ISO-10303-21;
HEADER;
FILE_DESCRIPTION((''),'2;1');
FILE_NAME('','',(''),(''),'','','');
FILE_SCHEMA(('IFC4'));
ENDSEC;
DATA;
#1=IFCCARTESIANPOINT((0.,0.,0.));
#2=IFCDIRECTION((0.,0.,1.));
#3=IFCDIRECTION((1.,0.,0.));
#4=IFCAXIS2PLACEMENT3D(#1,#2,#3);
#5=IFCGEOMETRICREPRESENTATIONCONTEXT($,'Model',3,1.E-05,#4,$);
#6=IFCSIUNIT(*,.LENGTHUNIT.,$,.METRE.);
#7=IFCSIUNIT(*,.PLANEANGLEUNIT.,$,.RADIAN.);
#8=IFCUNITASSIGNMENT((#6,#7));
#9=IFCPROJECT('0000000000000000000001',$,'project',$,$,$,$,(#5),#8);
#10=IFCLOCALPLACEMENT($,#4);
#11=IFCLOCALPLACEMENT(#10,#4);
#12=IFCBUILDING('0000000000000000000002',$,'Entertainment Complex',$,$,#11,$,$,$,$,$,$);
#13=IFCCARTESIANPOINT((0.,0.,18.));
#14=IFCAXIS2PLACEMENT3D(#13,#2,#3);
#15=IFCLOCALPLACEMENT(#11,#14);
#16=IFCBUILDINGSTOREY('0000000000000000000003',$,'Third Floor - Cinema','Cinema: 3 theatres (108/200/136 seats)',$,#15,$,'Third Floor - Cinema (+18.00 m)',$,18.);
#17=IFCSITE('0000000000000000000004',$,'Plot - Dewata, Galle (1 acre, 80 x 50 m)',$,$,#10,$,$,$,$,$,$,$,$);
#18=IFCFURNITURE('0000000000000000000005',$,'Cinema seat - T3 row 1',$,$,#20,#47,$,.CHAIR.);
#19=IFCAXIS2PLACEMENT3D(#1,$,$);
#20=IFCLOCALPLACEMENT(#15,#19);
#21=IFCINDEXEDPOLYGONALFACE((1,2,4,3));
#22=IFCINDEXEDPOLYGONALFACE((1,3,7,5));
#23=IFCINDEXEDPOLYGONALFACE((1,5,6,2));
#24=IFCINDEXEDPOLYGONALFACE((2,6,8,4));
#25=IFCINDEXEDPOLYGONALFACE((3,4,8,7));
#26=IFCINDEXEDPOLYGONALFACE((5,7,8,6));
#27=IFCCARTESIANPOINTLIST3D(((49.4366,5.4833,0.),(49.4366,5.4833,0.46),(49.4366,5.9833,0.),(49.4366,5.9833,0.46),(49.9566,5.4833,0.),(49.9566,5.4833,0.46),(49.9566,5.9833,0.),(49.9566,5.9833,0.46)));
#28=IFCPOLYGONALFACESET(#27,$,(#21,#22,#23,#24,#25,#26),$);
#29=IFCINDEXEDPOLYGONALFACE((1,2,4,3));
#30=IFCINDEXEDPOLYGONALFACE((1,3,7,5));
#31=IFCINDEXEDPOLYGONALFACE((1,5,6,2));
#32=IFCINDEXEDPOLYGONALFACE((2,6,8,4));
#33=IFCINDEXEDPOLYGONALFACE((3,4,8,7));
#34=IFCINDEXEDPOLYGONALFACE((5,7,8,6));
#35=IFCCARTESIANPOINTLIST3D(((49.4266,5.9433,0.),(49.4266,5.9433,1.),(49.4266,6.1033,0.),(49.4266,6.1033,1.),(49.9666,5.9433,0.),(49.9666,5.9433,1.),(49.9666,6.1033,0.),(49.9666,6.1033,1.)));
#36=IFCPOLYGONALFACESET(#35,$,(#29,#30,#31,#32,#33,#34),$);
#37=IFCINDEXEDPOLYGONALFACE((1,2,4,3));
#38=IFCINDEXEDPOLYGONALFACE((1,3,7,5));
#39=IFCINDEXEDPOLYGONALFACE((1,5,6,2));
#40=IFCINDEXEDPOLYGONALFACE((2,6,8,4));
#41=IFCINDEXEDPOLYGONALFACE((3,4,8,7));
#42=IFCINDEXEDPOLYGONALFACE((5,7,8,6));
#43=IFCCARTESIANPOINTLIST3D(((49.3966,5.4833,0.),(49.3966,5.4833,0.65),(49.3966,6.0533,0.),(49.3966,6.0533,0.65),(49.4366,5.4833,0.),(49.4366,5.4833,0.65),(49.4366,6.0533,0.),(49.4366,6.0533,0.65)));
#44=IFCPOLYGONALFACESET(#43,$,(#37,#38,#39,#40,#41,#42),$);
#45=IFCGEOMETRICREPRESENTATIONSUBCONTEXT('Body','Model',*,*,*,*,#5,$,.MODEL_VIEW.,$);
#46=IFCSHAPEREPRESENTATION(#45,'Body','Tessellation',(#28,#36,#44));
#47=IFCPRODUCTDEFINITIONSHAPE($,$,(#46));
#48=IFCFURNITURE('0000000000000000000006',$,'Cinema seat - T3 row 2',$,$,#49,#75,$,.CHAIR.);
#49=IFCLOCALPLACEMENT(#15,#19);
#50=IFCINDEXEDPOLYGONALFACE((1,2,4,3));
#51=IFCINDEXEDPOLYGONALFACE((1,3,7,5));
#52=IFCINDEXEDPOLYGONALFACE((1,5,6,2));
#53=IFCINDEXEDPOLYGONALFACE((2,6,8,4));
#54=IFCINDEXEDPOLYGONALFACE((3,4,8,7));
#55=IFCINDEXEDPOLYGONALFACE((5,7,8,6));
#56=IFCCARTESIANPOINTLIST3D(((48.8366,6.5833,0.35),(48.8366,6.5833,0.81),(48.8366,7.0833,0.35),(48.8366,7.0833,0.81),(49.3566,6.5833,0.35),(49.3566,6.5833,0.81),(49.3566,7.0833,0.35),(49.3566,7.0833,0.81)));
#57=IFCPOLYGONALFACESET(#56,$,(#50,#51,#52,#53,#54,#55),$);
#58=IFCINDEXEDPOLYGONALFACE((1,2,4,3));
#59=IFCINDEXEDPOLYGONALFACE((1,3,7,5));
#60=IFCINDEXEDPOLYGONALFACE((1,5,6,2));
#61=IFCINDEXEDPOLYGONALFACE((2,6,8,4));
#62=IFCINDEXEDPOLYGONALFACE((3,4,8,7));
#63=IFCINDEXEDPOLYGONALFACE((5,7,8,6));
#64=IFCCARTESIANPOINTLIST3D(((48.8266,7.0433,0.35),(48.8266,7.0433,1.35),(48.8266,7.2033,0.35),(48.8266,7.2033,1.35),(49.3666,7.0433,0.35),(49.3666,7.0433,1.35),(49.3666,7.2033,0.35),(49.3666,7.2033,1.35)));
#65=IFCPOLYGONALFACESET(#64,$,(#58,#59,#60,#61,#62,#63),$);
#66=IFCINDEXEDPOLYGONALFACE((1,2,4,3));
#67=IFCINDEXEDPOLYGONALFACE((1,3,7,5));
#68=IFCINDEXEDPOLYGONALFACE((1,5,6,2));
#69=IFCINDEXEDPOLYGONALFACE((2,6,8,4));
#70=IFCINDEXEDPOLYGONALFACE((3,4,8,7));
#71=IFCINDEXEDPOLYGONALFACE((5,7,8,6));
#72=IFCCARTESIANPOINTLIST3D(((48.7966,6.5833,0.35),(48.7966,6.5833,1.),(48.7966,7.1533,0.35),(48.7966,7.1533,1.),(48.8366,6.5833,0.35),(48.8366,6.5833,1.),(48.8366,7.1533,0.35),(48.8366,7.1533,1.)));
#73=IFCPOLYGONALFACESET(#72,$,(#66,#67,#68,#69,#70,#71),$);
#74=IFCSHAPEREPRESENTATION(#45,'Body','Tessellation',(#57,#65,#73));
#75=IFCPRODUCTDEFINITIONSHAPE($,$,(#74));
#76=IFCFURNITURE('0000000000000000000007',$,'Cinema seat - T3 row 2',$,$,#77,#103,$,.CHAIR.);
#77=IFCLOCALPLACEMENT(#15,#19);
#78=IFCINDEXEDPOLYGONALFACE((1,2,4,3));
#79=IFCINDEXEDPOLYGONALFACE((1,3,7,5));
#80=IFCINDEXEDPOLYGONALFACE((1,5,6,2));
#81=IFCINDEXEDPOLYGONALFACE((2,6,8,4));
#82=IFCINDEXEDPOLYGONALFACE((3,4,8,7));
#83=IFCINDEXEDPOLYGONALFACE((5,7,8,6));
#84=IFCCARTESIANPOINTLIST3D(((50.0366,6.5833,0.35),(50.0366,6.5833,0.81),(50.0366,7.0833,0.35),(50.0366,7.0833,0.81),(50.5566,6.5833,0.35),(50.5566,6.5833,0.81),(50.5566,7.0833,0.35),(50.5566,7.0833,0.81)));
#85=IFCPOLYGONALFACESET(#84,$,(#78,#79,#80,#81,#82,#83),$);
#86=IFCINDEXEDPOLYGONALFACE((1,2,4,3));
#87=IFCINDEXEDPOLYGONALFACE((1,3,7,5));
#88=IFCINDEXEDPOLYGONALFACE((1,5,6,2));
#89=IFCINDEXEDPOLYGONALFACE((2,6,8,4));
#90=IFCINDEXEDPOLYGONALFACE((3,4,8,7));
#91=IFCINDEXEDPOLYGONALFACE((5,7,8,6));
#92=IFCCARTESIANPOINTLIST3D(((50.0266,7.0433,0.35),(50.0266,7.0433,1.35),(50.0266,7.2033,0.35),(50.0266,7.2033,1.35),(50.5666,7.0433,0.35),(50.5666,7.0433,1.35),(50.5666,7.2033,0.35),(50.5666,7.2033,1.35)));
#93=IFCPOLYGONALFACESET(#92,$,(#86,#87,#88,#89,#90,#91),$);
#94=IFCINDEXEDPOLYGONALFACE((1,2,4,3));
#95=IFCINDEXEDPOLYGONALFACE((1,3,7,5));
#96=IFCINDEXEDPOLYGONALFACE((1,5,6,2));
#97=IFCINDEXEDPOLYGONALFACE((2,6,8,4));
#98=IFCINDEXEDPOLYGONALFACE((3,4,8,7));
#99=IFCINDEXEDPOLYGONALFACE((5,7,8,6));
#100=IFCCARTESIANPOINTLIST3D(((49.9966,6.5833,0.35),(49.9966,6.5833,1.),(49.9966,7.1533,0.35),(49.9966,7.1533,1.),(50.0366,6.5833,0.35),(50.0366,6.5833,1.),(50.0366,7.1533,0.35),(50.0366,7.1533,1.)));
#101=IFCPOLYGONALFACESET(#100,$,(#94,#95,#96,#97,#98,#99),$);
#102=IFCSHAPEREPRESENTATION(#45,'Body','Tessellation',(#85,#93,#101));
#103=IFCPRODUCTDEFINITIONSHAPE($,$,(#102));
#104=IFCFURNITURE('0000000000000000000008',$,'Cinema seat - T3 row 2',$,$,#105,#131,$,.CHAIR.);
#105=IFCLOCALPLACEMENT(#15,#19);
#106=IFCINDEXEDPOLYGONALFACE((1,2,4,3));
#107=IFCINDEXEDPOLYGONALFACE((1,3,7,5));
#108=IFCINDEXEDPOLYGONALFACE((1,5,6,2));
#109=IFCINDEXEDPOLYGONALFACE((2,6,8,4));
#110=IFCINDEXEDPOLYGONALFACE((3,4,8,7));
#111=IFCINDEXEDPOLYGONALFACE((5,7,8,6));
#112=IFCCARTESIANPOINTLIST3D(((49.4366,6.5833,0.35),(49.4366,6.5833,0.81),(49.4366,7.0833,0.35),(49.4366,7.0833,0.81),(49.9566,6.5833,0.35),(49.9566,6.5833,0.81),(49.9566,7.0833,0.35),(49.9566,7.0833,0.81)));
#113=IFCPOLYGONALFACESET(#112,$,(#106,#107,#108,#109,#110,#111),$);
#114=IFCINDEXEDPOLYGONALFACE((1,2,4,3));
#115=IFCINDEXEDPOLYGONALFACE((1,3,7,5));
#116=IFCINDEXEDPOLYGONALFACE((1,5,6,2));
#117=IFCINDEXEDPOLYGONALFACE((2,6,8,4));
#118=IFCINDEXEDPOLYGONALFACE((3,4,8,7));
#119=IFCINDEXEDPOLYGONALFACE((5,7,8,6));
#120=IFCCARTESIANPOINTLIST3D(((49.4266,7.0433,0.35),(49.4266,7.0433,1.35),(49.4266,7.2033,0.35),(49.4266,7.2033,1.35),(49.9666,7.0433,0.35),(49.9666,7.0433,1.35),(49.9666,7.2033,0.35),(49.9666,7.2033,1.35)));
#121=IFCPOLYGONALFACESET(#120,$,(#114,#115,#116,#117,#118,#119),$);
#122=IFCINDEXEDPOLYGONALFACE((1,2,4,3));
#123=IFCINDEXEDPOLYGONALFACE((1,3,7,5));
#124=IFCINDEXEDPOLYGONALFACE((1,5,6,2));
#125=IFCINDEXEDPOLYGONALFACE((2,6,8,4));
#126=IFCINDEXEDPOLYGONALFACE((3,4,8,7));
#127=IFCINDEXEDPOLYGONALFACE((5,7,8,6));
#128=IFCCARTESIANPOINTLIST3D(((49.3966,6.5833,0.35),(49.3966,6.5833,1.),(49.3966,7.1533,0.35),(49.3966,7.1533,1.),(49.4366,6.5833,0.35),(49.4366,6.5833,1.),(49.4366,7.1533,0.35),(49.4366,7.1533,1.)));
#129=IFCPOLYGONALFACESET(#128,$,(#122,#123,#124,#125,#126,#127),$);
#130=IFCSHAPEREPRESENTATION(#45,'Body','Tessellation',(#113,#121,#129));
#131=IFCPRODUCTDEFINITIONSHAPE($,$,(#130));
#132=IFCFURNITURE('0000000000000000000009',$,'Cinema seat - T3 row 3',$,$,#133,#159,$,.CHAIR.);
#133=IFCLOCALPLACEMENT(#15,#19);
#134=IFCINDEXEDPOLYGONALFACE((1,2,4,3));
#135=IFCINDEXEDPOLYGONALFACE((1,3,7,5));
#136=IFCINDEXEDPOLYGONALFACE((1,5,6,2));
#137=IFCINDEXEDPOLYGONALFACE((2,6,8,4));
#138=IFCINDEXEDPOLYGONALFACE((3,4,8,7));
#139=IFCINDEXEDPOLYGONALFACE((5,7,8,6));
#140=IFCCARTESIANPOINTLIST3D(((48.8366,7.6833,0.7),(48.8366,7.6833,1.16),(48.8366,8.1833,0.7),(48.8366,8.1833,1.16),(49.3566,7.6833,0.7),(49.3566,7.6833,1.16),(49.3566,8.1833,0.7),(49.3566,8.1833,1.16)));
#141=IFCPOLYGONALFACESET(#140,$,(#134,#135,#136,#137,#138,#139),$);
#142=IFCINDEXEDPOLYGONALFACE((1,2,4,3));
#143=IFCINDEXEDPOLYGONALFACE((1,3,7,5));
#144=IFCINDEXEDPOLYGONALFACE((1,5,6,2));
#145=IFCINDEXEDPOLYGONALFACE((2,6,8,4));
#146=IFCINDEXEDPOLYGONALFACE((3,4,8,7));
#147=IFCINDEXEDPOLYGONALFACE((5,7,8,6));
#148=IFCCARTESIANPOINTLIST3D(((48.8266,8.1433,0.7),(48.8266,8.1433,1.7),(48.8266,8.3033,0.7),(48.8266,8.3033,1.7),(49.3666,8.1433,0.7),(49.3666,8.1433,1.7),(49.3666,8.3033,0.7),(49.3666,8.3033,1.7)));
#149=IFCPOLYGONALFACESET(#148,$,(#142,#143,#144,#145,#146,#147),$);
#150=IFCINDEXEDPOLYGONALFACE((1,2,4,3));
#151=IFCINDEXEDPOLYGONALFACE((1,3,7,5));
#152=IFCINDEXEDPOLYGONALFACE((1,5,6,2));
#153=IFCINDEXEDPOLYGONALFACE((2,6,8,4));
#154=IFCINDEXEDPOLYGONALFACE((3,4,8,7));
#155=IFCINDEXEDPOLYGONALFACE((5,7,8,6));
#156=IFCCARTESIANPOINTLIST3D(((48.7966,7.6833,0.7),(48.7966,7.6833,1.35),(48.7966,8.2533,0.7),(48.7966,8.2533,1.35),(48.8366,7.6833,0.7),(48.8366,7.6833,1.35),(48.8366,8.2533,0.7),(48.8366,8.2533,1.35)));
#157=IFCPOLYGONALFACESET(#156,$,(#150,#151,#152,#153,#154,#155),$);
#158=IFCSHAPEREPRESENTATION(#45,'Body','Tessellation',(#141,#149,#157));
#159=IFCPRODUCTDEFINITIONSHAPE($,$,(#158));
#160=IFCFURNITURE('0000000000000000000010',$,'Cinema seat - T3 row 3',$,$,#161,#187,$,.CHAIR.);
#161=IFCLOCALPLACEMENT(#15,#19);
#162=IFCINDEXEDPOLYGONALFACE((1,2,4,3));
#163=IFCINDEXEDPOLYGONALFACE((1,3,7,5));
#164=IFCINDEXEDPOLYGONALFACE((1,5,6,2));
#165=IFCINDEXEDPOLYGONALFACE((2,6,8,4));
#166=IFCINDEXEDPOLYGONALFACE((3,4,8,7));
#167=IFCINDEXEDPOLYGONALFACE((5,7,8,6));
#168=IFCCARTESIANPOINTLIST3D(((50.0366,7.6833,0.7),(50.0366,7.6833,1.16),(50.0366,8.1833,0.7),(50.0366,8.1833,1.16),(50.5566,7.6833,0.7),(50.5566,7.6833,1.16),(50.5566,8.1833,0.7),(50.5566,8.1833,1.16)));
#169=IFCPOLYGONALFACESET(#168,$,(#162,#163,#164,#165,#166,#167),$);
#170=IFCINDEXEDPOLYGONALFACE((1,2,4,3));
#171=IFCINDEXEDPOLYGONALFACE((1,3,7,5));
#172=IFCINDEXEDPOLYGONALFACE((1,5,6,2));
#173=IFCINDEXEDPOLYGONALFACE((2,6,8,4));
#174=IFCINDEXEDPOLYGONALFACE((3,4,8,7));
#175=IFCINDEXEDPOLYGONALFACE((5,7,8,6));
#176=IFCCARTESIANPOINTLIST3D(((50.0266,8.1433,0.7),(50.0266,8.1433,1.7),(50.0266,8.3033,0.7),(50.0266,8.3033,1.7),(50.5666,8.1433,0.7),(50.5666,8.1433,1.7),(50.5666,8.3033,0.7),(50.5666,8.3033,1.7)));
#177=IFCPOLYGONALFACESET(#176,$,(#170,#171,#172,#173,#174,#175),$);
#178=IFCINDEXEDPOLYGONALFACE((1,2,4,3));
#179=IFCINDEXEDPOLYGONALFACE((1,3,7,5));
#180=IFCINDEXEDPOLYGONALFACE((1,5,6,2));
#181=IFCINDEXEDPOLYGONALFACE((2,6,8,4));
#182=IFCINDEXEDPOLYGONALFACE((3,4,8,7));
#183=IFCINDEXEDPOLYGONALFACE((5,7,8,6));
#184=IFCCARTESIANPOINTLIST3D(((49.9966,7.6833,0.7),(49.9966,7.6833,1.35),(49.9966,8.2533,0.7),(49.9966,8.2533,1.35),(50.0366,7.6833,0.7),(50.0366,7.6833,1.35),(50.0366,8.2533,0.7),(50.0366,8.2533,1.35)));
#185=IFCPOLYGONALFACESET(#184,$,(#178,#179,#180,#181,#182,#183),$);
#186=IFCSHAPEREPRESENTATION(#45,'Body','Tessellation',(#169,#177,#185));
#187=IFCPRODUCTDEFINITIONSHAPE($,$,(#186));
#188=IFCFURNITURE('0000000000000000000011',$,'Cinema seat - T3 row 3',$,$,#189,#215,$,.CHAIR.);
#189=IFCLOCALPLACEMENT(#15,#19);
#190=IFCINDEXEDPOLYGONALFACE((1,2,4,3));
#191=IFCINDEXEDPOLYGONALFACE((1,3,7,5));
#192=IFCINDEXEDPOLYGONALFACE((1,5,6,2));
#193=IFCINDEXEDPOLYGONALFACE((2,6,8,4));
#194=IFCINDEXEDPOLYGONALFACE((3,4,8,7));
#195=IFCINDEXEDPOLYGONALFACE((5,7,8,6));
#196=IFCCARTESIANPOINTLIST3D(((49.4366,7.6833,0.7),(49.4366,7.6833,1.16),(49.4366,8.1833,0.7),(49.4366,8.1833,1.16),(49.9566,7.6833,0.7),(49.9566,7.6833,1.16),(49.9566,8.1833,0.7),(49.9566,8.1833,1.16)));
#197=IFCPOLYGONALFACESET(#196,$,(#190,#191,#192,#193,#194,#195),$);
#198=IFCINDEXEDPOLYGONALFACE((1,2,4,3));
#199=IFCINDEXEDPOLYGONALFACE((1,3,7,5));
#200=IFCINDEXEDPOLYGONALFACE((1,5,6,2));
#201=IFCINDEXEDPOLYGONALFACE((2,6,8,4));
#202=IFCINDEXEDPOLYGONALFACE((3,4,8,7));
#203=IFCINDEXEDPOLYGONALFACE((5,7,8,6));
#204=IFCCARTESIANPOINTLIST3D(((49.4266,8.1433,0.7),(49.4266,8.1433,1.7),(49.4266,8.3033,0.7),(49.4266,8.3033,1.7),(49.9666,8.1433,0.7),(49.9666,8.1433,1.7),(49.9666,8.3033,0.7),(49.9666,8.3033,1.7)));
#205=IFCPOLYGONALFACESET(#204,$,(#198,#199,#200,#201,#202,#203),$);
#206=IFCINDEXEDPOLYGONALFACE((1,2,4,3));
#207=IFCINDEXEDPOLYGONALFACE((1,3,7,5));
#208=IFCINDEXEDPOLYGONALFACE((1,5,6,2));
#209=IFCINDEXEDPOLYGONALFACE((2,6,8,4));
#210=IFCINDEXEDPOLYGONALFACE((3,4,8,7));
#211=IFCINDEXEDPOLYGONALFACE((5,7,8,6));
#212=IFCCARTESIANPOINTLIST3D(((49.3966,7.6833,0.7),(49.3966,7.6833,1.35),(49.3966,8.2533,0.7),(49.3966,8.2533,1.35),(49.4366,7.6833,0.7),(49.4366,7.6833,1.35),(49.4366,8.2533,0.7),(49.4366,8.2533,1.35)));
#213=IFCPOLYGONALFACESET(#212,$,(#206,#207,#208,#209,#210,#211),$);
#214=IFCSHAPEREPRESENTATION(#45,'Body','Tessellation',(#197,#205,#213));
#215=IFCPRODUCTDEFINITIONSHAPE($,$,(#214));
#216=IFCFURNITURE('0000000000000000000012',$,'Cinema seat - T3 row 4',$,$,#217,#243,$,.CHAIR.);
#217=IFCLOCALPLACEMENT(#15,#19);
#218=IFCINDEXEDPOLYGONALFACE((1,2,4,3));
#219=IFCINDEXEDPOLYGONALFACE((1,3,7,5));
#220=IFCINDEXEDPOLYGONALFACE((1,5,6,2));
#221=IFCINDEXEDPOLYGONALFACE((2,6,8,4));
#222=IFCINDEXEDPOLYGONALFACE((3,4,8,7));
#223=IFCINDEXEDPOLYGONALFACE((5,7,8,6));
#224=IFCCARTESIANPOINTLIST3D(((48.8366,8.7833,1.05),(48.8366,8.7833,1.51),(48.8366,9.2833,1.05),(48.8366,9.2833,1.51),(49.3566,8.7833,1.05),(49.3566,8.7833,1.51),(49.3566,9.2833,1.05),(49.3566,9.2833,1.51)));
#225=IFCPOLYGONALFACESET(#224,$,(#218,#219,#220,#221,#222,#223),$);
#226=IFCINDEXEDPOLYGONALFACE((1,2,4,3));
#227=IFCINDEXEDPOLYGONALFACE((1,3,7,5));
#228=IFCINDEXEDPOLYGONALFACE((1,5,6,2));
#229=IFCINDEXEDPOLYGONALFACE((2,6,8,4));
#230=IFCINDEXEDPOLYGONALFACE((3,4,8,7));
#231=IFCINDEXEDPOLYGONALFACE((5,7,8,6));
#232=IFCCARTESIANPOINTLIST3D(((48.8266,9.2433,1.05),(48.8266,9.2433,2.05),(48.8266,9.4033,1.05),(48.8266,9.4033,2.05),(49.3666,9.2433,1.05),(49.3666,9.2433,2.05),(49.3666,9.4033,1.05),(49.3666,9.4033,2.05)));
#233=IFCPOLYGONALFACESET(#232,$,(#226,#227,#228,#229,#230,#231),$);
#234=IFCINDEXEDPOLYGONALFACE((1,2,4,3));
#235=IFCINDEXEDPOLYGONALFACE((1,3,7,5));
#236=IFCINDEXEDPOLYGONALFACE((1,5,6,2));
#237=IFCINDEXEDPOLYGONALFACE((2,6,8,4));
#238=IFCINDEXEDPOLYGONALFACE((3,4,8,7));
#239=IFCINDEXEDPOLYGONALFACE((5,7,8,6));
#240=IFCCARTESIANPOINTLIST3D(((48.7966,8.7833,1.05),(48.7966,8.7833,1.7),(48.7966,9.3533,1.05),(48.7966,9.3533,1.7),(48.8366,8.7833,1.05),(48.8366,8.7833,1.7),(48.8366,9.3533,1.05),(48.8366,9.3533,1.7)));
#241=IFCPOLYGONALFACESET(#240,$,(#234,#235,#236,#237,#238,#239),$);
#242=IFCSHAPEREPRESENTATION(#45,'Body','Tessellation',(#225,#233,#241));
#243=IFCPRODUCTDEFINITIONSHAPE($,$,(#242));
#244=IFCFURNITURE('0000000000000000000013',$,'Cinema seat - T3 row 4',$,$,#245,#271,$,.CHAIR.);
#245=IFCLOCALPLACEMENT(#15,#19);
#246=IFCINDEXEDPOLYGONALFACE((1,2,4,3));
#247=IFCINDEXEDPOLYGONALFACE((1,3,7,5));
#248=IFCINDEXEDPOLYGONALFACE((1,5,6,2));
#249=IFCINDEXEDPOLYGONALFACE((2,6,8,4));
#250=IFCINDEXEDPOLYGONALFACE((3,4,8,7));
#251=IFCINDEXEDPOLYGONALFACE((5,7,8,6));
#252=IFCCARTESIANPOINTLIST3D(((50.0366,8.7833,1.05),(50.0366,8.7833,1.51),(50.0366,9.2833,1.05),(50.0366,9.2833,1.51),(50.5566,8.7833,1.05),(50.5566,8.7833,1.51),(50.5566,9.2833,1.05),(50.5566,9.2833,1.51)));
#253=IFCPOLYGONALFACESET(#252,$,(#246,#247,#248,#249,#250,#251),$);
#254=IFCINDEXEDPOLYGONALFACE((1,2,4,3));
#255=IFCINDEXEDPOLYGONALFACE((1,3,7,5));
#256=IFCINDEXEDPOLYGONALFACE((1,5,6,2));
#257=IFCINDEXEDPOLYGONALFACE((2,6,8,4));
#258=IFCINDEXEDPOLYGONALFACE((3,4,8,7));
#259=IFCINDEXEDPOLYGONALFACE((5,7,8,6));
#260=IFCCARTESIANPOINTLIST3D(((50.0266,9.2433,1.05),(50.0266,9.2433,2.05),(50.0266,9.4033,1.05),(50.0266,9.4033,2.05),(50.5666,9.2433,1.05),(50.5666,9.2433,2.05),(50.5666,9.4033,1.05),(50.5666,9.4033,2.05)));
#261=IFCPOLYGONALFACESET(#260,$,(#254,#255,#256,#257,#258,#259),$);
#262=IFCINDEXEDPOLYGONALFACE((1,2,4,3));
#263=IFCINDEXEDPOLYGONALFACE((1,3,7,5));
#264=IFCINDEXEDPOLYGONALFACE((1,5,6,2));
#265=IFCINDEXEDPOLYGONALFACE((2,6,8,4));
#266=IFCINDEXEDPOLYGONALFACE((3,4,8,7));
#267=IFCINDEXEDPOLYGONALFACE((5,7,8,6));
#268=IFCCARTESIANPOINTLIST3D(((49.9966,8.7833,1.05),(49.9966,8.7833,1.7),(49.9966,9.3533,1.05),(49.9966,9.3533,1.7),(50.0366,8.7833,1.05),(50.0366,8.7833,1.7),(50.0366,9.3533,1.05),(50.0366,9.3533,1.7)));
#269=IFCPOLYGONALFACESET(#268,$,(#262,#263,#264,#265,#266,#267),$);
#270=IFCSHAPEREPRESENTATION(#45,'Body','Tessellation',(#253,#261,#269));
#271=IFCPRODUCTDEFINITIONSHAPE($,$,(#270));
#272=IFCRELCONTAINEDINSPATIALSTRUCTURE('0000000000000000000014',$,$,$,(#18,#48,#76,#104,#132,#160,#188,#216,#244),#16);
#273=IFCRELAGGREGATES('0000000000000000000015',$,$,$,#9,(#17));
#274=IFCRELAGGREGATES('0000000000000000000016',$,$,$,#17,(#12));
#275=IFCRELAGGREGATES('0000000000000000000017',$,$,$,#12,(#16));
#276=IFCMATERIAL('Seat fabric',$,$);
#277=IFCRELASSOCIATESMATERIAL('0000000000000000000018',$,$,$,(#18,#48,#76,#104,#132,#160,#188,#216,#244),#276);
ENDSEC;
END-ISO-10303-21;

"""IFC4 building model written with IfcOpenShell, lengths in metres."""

from ifc_helpers import new_model, si_unit, frame, origin_with_axes, place, context, subcontext, project, spatial, polyline, outline, extrude, material, element, save


model = new_model("IFC4")

# Units and contexts
model_context = context("Model", 3, precision=1e-05, world=origin_with_axes())
body_context = subcontext(model_context, "Body", "Model", "MODEL_VIEW")
ifc_project = project(units=[si_unit("LENGTHUNIT", "METRE"), si_unit("PLANEANGLEUNIT", "RADIAN")], contexts=[model_context])

# Site, building, storey
site_placement = place(None, origin_with_axes())
site = spatial("IfcSite", under=ifc_project, at=site_placement, Name="Plot - Dewata, Galle (1 acre, 80 x 50 m)")
building_placement = place(site_placement, origin_with_axes())
building = spatial("IfcBuilding", under=site, at=building_placement, Name="Entertainment Complex")
storey_placement = place(building_placement, frame((0.0, 0.0, 18.0), z_axis=(0.0, 0.0, 1.0), x_axis=(1.0, 0.0, 0.0)))
storey = spatial("IfcBuildingStorey", under=building, at=storey_placement, Name="Third Floor - Cinema", Description="Cinema: 3 theatres (108/200/136 seats)", LongName="Third Floor - Cinema (+18.00 m)", Elevation=18.0)

# Furniture
ifc_material_1 = material(Name="Seat fabric")
for number, where, z_axis, x_axis, name in (
    (1, (49.6966, 6.1033, 0.0), (0.0, 0.0, 1.0), (0.0, 1.0, 0.0), "Cinema seat - T3 row 1"),
    (2, (49.0966, 7.2033, 0.35), (0.0, 0.0, 1.0), (0.0, 1.0, 0.0), "Cinema seat - T3 row 2"),
    (3, (50.2966, 7.2033, 0.35), (0.0, 0.0, 1.0), (0.0, 1.0, 0.0), "Cinema seat - T3 row 2"),
    (4, (49.6966, 7.2033, 0.35), (0.0, 0.0, 1.0), (0.0, 1.0, 0.0), "Cinema seat - T3 row 2"),
    (5, (49.0966, 8.3033, 0.7), (0.0, 0.0, 1.0), (0.0, 1.0, 0.0), "Cinema seat - T3 row 3"),
    (6, (50.2966, 8.3033, 0.7), (0.0, 0.0, 1.0), (0.0, 1.0, 0.0), "Cinema seat - T3 row 3"),
    (7, (49.6966, 8.3033, 0.7), (0.0, 0.0, 1.0), (0.0, 1.0, 0.0), "Cinema seat - T3 row 3"),
    (8, (49.0966, 9.4033, 1.05), (0.0, 0.0, 1.0), (0.0, 1.0, 0.0), "Cinema seat - T3 row 4"),
    (9, (50.2966, 9.4033, 1.05), (0.0, 0.0, 1.0), (0.0, 1.0, 0.0), "Cinema seat - T3 row 4"),
):
    element("IfcFurniture", number, at=place(storey_placement, frame(where, z_axis=z_axis, x_axis=x_axis)), inside=storey, material=ifc_material_1, Name=name, PredefinedType="CHAIR", context=body_context, shape_type="SweptSolid", body=[
        extrude(outline(polyline([(-0.62, -0.26), (-0.12, -0.26), (-0.12, 0.26), (-0.62, 0.26), (-0.62, -0.26)])), origin_with_axes(), (0.0, 0.0, 1.0), 0.46),
        extrude(outline(polyline([(-0.16, -0.27), (0.0, -0.27), (0.0, 0.27), (-0.16, 0.27), (-0.16, -0.27)])), origin_with_axes(), (0.0, 0.0, 1.0), 1.0),
        extrude(outline(polyline([(-0.62, 0.26), (-0.05, 0.26), (-0.05, 0.3), (-0.62, 0.3), (-0.62, 0.26)])), origin_with_axes(), (0.0, 0.0, 1.0), 0.65),
    ])

save(model, "model.ifc")
